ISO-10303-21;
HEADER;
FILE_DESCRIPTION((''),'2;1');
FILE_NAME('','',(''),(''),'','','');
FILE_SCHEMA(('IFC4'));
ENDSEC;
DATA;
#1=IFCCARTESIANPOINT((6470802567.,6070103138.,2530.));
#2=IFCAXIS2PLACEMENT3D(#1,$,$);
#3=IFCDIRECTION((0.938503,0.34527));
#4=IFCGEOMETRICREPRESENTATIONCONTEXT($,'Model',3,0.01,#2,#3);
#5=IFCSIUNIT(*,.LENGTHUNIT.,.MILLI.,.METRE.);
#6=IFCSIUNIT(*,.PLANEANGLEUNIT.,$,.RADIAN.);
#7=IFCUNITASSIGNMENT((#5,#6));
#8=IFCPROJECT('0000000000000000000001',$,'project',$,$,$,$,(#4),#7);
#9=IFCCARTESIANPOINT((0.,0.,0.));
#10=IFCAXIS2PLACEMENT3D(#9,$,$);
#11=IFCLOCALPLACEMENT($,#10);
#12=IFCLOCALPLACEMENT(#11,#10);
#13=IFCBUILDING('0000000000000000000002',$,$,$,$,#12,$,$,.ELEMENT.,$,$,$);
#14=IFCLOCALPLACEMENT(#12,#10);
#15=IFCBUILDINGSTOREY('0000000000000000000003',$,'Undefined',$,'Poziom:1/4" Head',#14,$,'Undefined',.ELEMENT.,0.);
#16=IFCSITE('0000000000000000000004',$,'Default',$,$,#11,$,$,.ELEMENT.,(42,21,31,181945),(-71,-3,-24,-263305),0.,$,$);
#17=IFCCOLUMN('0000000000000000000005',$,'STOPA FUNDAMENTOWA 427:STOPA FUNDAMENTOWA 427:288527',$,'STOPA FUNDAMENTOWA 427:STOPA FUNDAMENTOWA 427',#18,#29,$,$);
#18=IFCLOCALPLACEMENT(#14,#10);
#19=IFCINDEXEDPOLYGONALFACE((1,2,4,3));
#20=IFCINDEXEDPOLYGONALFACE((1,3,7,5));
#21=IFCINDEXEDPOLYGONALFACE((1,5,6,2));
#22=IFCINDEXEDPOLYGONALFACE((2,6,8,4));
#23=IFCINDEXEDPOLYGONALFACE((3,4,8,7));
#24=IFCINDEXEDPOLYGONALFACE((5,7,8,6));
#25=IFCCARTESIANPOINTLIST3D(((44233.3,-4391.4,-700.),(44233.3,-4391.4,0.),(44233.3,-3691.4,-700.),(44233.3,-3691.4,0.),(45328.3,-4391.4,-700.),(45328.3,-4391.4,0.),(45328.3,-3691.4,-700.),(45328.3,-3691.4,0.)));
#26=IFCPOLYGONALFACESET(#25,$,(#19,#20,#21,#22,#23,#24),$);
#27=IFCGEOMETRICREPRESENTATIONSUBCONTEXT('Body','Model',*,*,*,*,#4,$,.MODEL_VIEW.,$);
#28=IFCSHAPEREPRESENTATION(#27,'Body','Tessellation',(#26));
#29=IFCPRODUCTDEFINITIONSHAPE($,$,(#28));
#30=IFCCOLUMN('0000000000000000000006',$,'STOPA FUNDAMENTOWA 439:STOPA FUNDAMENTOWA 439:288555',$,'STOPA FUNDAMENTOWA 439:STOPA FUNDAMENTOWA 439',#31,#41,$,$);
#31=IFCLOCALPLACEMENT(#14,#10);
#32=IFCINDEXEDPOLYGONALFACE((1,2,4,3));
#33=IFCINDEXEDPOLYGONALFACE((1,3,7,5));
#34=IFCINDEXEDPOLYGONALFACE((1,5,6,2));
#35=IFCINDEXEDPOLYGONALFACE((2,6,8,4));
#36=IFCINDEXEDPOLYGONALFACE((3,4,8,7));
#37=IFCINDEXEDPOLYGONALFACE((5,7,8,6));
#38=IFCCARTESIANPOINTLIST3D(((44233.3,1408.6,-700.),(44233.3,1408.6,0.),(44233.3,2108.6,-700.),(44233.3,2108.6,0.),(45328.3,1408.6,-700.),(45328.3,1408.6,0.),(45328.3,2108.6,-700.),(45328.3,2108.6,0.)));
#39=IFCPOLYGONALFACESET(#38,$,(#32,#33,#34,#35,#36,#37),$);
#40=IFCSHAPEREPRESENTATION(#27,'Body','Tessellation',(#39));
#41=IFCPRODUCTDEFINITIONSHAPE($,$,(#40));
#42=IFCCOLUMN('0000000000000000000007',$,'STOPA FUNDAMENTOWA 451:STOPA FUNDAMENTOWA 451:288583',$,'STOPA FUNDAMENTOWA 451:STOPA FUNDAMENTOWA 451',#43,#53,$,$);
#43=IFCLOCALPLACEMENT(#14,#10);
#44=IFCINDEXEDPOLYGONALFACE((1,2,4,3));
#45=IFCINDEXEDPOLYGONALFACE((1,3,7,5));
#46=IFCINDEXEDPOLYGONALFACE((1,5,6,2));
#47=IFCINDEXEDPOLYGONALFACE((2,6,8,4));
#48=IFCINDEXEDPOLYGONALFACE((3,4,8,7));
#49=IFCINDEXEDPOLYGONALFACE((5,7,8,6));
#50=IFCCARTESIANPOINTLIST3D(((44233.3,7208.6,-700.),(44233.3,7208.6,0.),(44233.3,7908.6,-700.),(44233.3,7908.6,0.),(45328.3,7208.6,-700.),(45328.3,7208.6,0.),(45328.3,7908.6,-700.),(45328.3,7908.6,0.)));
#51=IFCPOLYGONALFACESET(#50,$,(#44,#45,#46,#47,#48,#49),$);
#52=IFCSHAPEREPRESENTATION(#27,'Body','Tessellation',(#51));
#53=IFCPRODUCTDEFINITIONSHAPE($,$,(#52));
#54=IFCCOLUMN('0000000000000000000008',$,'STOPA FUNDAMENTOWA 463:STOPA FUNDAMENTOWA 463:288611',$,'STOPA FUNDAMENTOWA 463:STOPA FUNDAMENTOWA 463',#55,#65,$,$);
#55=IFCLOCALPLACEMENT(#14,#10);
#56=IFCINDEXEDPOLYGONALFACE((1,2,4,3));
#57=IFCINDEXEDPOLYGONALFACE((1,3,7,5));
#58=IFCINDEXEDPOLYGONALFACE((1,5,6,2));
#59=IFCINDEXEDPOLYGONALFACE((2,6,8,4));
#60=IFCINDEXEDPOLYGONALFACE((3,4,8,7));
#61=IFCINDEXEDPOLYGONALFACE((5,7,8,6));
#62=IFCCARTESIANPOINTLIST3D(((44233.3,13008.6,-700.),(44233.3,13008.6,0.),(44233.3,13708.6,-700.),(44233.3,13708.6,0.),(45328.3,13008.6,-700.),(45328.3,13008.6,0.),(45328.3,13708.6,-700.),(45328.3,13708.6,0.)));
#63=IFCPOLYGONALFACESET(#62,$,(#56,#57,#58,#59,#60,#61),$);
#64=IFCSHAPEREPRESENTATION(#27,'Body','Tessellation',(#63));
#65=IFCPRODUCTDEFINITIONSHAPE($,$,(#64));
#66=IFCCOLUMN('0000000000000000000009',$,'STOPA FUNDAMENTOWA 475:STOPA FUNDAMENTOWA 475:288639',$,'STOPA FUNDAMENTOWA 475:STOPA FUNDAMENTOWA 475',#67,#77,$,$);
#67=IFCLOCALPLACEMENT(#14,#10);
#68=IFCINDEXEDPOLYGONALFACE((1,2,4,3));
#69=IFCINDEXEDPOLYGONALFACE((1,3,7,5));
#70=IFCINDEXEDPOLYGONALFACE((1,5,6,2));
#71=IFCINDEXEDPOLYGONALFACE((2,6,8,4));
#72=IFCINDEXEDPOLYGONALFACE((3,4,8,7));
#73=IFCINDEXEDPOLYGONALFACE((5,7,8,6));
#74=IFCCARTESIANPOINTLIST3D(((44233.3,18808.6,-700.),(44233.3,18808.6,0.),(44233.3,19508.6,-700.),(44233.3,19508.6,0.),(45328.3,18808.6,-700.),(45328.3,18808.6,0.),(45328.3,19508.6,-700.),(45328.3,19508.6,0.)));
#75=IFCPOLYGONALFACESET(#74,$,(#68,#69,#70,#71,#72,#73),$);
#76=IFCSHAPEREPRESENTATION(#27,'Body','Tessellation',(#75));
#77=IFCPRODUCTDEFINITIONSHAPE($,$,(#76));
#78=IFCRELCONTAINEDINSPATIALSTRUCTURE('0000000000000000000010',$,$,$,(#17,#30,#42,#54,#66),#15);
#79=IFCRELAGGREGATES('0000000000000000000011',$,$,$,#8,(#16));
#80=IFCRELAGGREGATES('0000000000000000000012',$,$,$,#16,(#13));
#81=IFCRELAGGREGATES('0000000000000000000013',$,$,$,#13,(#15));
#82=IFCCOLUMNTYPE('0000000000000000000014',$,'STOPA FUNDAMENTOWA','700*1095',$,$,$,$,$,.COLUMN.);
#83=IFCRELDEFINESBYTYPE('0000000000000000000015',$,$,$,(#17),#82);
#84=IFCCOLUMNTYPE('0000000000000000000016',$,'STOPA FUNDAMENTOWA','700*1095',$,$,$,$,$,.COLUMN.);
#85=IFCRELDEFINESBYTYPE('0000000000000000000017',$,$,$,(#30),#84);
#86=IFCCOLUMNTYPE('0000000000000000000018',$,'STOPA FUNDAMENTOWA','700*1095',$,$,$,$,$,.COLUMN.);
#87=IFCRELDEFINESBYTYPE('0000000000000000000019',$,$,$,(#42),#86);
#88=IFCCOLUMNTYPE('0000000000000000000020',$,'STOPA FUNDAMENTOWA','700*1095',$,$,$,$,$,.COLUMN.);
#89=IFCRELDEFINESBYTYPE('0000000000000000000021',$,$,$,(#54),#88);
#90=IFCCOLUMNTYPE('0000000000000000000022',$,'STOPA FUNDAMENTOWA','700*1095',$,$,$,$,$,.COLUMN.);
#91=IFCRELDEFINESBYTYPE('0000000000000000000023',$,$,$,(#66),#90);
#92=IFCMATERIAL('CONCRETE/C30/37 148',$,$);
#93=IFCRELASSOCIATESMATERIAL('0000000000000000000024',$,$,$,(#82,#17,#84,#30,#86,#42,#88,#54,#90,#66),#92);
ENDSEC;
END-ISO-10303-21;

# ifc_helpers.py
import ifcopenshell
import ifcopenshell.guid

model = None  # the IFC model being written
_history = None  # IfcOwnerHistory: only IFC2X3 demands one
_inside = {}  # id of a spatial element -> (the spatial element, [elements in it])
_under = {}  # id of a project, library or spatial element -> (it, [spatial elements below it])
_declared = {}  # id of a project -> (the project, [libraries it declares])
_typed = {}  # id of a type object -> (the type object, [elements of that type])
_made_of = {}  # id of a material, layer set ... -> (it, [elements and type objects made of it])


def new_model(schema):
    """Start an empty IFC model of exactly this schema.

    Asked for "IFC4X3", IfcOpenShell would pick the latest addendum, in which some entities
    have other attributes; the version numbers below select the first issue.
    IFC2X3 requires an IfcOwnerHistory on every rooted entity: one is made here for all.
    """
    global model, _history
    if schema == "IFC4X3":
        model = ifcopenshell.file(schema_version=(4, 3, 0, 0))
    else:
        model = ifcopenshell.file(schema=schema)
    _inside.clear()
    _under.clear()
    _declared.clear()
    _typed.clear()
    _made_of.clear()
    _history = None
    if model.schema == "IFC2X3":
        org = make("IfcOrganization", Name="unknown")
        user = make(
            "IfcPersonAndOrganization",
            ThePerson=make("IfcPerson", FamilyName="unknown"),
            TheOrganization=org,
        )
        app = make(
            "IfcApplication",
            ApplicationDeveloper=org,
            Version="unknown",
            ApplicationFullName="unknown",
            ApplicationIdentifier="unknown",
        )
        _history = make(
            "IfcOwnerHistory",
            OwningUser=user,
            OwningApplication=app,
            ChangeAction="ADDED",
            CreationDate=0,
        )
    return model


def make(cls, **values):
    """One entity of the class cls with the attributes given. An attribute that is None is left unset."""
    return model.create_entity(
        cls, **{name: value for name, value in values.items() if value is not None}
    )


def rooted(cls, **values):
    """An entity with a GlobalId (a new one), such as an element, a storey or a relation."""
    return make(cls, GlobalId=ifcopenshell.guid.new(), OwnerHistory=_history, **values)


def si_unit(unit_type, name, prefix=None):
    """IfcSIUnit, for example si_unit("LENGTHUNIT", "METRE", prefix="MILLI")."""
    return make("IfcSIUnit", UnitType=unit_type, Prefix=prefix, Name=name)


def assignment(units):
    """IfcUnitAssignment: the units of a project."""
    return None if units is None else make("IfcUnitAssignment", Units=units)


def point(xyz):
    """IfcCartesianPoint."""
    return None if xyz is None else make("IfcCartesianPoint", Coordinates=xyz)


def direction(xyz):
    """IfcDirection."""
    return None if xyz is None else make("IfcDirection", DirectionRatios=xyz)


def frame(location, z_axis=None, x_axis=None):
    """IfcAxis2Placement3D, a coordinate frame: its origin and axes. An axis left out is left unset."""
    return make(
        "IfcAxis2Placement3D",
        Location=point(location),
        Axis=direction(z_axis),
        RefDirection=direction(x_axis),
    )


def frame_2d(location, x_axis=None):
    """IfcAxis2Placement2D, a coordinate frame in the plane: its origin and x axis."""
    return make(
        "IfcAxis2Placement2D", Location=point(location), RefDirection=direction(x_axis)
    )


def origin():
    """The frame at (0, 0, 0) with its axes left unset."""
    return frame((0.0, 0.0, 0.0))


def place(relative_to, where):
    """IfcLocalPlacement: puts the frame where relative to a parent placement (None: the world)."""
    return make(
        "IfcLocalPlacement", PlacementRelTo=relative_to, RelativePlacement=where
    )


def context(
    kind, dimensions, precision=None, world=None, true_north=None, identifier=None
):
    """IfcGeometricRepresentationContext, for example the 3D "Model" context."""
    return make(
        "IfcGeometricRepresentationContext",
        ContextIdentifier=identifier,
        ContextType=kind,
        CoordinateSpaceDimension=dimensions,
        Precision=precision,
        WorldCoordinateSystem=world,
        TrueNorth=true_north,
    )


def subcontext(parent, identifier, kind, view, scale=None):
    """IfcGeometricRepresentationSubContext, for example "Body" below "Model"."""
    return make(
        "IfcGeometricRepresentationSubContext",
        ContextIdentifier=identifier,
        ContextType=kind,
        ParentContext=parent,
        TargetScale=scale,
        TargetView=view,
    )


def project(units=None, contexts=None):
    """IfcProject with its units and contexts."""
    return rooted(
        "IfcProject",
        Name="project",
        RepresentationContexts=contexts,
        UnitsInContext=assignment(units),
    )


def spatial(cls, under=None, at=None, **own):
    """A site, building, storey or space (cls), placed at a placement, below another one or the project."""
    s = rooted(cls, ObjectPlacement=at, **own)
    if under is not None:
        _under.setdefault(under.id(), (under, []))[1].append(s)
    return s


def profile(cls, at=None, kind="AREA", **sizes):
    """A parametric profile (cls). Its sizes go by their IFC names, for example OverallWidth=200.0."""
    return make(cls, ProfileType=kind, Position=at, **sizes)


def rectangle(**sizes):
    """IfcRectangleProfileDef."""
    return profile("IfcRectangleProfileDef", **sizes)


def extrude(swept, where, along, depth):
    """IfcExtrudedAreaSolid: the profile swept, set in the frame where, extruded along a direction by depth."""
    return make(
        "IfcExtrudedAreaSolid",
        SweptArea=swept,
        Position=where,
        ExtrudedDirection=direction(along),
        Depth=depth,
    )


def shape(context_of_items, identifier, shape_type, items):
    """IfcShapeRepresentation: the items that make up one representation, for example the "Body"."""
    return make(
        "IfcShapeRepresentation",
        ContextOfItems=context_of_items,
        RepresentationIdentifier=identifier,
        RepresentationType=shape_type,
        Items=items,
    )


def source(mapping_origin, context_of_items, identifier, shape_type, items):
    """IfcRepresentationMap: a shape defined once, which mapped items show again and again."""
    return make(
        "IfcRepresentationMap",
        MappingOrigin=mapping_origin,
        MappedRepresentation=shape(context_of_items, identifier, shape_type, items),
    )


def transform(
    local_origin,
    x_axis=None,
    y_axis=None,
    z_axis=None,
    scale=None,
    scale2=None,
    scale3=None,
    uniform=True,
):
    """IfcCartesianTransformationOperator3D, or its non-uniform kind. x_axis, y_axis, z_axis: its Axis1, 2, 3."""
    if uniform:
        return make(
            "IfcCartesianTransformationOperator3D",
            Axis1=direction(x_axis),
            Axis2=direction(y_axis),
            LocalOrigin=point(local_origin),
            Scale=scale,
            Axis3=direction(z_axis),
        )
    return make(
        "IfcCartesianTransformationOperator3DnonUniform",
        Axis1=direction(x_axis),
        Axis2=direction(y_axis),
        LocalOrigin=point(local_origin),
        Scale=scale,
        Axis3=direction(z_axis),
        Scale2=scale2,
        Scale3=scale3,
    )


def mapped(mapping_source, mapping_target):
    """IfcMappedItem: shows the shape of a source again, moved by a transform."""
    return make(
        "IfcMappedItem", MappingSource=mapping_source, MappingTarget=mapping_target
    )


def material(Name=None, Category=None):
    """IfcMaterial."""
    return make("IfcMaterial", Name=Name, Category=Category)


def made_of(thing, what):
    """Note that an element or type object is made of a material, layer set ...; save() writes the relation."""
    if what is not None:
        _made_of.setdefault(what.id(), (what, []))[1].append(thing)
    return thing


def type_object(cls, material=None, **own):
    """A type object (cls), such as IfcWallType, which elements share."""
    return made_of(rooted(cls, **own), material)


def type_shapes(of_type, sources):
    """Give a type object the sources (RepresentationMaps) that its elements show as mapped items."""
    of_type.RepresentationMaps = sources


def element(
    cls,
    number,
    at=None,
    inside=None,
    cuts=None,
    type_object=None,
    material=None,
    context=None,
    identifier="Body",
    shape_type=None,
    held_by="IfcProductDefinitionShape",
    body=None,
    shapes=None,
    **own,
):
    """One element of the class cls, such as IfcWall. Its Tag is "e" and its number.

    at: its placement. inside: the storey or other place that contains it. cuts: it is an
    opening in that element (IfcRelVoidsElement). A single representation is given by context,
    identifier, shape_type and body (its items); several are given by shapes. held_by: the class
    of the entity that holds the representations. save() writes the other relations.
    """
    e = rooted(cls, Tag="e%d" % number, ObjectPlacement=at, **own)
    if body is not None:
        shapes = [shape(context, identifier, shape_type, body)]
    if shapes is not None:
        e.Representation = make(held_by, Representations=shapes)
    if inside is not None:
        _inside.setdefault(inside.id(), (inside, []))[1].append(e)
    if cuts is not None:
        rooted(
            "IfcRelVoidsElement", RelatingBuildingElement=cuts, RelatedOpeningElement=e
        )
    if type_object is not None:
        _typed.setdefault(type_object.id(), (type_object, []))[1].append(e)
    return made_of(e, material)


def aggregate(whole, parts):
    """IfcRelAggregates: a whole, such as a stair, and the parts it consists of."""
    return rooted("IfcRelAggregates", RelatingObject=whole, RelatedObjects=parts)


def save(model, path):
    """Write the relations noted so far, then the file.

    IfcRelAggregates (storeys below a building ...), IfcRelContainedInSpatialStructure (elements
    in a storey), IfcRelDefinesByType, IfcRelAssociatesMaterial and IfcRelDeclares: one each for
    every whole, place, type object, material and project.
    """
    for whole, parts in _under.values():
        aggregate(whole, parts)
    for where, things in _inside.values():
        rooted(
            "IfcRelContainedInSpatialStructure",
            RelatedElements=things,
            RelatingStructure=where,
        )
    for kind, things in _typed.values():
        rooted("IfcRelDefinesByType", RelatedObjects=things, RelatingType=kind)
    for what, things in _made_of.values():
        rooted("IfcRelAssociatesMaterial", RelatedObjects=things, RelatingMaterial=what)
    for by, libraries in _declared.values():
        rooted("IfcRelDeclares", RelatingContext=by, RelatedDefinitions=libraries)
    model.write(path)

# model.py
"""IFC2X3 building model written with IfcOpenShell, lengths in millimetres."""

from ifc_helpers import new_model, si_unit, direction, frame, frame_2d, origin, place, context, subcontext, project, spatial, rectangle, extrude, source, transform, mapped, material, type_object, type_shapes, element, save


model = new_model("IFC2X3")

# Units and contexts
model_context = context("Model", 3, precision=0.01, world=frame((6470802567.0, 6070103138.0, 2530.0)), true_north=direction((0.938503, 0.34527)))
body_context = subcontext(model_context, "Body", "Model", "MODEL_VIEW")
ifc_project = project(units=[si_unit("LENGTHUNIT", "METRE", prefix="MILLI"), si_unit("PLANEANGLEUNIT", "RADIAN")], contexts=[model_context])

# Site, building, storey
site_placement = place(None, origin())
site = spatial("IfcSite", under=ifc_project, at=site_placement, Name="Default", CompositionType="ELEMENT", RefLatitude=(42, 21, 31, 181945), RefLongitude=(-71, -3, -24, -263305), RefElevation=0.0)
building_placement = place(site_placement, origin())
building = spatial("IfcBuilding", under=site, at=building_placement, CompositionType="ELEMENT")
storey_placement = place(building_placement, origin())
storey = spatial("IfcBuildingStorey", under=building, at=storey_placement, Name="Undefined", ObjectType="Poziom:1/4\" Head", LongName="Undefined", CompositionType="ELEMENT", Elevation=0.0)

# Shared definitions
ifc_material = material(Name="CONCRETE/C30/37 148")

# Columns
column_type_1 = type_object("IfcColumnType", Name="STOPA FUNDAMENTOWA", Description="700*1095", PredefinedType="COLUMN", material=ifc_material)
shared_shape_1 = source(origin(), body_context, "Body", "SweptSolid", [
    extrude(rectangle(XDim=700.0, YDim=1095.0, at=frame_2d((0.0, 0.0), x_axis=(1.0, 0.0))), frame((44780.8, -4041.4, -700.0), z_axis=(0.0, 0.0, 1.0), x_axis=(0.0, 1.0, 0.0)), (0.0, 0.0, 1.0), 700.0),
])
type_shapes(column_type_1, [shared_shape_1])
column_1_placement = place(storey_placement, origin())
element("IfcColumn", 1, at=column_1_placement, inside=storey, type_object=column_type_1, material=ifc_material, Name="STOPA FUNDAMENTOWA 427:STOPA FUNDAMENTOWA 427:288527", ObjectType="STOPA FUNDAMENTOWA 427:STOPA FUNDAMENTOWA 427", context=body_context, shape_type="MappedRepresentation", body=[
    mapped(shared_shape_1, transform((0.0, 0.0, 0.0), scale=1.0)),
])
column_type_2 = type_object("IfcColumnType", Name="STOPA FUNDAMENTOWA", Description="700*1095", PredefinedType="COLUMN", material=ifc_material)
shared_shape_2 = source(origin(), body_context, "Body", "SweptSolid", [
    extrude(rectangle(XDim=700.0, YDim=1095.0, at=frame_2d((0.0, 0.0), x_axis=(1.0, 0.0))), frame((44780.8, 1758.6, -700.0), z_axis=(0.0, 0.0, 1.0), x_axis=(0.0, 1.0, 0.0)), (0.0, 0.0, 1.0), 700.0),
])
type_shapes(column_type_2, [shared_shape_2])
column_2_placement = place(storey_placement, origin())
element("IfcColumn", 2, at=column_2_placement, inside=storey, type_object=column_type_2, material=ifc_material, Name="STOPA FUNDAMENTOWA 439:STOPA FUNDAMENTOWA 439:288555", ObjectType="STOPA FUNDAMENTOWA 439:STOPA FUNDAMENTOWA 439", context=body_context, shape_type="MappedRepresentation", body=[
    mapped(shared_shape_2, transform((0.0, 0.0, 0.0), scale=1.0)),
])
column_type_3 = type_object("IfcColumnType", Name="STOPA FUNDAMENTOWA", Description="700*1095", PredefinedType="COLUMN", material=ifc_material)
shared_shape_3 = source(origin(), body_context, "Body", "SweptSolid", [
    extrude(rectangle(XDim=700.0, YDim=1095.0, at=frame_2d((0.0, 0.0), x_axis=(1.0, 0.0))), frame((44780.8, 7558.6, -700.0), z_axis=(0.0, 0.0, 1.0), x_axis=(0.0, 1.0, 0.0)), (0.0, 0.0, 1.0), 700.0),
])
type_shapes(column_type_3, [shared_shape_3])
column_3_placement = place(storey_placement, origin())
element("IfcColumn", 3, at=column_3_placement, inside=storey, type_object=column_type_3, material=ifc_material, Name="STOPA FUNDAMENTOWA 451:STOPA FUNDAMENTOWA 451:288583", ObjectType="STOPA FUNDAMENTOWA 451:STOPA FUNDAMENTOWA 451", context=body_context, shape_type="MappedRepresentation", body=[
    mapped(shared_shape_3, transform((0.0, 0.0, 0.0), scale=1.0)),
])
column_type_4 = type_object("IfcColumnType", Name="STOPA FUNDAMENTOWA", Description="700*1095", PredefinedType="COLUMN", material=ifc_material)
shared_shape_4 = source(origin(), body_context, "Body", "SweptSolid", [
    extrude(rectangle(XDim=700.0, YDim=1095.0, at=frame_2d((0.0, 0.0), x_axis=(1.0, 0.0))), frame((44780.8, 13358.6, -700.0), z_axis=(0.0, 0.0, 1.0), x_axis=(0.0, 1.0, 0.0)), (0.0, 0.0, 1.0), 700.0),
])
type_shapes(column_type_4, [shared_shape_4])
column_4_placement = place(storey_placement, origin())
element("IfcColumn", 4, at=column_4_placement, inside=storey, type_object=column_type_4, material=ifc_material, Name="STOPA FUNDAMENTOWA 463:STOPA FUNDAMENTOWA 463:288611", ObjectType="STOPA FUNDAMENTOWA 463:STOPA FUNDAMENTOWA 463", context=body_context, shape_type="MappedRepresentation", body=[
    mapped(shared_shape_4, transform((0.0, 0.0, 0.0), scale=1.0)),
])
column_type_5 = type_object("IfcColumnType", Name="STOPA FUNDAMENTOWA", Description="700*1095", PredefinedType="COLUMN", material=ifc_material)
shared_shape_5 = source(origin(), body_context, "Body", "SweptSolid", [
    extrude(rectangle(XDim=700.0, YDim=1095.0, at=frame_2d((0.0, 0.0), x_axis=(1.0, 0.0))), frame((44780.8, 19158.6, -700.0), z_axis=(0.0, 0.0, 1.0), x_axis=(0.0, 1.0, 0.0)), (0.0, 0.0, 1.0), 700.0),
])
type_shapes(column_type_5, [shared_shape_5])
column_5_placement = place(storey_placement, origin())
element("IfcColumn", 5, at=column_5_placement, inside=storey, type_object=column_type_5, material=ifc_material, Name="STOPA FUNDAMENTOWA 475:STOPA FUNDAMENTOWA 475:288639", ObjectType="STOPA FUNDAMENTOWA 475:STOPA FUNDAMENTOWA 475", context=body_context, shape_type="MappedRepresentation", body=[
    mapped(shared_shape_5, transform((0.0, 0.0, 0.0), scale=1.0)),
])

save(model, "model.ifc")
